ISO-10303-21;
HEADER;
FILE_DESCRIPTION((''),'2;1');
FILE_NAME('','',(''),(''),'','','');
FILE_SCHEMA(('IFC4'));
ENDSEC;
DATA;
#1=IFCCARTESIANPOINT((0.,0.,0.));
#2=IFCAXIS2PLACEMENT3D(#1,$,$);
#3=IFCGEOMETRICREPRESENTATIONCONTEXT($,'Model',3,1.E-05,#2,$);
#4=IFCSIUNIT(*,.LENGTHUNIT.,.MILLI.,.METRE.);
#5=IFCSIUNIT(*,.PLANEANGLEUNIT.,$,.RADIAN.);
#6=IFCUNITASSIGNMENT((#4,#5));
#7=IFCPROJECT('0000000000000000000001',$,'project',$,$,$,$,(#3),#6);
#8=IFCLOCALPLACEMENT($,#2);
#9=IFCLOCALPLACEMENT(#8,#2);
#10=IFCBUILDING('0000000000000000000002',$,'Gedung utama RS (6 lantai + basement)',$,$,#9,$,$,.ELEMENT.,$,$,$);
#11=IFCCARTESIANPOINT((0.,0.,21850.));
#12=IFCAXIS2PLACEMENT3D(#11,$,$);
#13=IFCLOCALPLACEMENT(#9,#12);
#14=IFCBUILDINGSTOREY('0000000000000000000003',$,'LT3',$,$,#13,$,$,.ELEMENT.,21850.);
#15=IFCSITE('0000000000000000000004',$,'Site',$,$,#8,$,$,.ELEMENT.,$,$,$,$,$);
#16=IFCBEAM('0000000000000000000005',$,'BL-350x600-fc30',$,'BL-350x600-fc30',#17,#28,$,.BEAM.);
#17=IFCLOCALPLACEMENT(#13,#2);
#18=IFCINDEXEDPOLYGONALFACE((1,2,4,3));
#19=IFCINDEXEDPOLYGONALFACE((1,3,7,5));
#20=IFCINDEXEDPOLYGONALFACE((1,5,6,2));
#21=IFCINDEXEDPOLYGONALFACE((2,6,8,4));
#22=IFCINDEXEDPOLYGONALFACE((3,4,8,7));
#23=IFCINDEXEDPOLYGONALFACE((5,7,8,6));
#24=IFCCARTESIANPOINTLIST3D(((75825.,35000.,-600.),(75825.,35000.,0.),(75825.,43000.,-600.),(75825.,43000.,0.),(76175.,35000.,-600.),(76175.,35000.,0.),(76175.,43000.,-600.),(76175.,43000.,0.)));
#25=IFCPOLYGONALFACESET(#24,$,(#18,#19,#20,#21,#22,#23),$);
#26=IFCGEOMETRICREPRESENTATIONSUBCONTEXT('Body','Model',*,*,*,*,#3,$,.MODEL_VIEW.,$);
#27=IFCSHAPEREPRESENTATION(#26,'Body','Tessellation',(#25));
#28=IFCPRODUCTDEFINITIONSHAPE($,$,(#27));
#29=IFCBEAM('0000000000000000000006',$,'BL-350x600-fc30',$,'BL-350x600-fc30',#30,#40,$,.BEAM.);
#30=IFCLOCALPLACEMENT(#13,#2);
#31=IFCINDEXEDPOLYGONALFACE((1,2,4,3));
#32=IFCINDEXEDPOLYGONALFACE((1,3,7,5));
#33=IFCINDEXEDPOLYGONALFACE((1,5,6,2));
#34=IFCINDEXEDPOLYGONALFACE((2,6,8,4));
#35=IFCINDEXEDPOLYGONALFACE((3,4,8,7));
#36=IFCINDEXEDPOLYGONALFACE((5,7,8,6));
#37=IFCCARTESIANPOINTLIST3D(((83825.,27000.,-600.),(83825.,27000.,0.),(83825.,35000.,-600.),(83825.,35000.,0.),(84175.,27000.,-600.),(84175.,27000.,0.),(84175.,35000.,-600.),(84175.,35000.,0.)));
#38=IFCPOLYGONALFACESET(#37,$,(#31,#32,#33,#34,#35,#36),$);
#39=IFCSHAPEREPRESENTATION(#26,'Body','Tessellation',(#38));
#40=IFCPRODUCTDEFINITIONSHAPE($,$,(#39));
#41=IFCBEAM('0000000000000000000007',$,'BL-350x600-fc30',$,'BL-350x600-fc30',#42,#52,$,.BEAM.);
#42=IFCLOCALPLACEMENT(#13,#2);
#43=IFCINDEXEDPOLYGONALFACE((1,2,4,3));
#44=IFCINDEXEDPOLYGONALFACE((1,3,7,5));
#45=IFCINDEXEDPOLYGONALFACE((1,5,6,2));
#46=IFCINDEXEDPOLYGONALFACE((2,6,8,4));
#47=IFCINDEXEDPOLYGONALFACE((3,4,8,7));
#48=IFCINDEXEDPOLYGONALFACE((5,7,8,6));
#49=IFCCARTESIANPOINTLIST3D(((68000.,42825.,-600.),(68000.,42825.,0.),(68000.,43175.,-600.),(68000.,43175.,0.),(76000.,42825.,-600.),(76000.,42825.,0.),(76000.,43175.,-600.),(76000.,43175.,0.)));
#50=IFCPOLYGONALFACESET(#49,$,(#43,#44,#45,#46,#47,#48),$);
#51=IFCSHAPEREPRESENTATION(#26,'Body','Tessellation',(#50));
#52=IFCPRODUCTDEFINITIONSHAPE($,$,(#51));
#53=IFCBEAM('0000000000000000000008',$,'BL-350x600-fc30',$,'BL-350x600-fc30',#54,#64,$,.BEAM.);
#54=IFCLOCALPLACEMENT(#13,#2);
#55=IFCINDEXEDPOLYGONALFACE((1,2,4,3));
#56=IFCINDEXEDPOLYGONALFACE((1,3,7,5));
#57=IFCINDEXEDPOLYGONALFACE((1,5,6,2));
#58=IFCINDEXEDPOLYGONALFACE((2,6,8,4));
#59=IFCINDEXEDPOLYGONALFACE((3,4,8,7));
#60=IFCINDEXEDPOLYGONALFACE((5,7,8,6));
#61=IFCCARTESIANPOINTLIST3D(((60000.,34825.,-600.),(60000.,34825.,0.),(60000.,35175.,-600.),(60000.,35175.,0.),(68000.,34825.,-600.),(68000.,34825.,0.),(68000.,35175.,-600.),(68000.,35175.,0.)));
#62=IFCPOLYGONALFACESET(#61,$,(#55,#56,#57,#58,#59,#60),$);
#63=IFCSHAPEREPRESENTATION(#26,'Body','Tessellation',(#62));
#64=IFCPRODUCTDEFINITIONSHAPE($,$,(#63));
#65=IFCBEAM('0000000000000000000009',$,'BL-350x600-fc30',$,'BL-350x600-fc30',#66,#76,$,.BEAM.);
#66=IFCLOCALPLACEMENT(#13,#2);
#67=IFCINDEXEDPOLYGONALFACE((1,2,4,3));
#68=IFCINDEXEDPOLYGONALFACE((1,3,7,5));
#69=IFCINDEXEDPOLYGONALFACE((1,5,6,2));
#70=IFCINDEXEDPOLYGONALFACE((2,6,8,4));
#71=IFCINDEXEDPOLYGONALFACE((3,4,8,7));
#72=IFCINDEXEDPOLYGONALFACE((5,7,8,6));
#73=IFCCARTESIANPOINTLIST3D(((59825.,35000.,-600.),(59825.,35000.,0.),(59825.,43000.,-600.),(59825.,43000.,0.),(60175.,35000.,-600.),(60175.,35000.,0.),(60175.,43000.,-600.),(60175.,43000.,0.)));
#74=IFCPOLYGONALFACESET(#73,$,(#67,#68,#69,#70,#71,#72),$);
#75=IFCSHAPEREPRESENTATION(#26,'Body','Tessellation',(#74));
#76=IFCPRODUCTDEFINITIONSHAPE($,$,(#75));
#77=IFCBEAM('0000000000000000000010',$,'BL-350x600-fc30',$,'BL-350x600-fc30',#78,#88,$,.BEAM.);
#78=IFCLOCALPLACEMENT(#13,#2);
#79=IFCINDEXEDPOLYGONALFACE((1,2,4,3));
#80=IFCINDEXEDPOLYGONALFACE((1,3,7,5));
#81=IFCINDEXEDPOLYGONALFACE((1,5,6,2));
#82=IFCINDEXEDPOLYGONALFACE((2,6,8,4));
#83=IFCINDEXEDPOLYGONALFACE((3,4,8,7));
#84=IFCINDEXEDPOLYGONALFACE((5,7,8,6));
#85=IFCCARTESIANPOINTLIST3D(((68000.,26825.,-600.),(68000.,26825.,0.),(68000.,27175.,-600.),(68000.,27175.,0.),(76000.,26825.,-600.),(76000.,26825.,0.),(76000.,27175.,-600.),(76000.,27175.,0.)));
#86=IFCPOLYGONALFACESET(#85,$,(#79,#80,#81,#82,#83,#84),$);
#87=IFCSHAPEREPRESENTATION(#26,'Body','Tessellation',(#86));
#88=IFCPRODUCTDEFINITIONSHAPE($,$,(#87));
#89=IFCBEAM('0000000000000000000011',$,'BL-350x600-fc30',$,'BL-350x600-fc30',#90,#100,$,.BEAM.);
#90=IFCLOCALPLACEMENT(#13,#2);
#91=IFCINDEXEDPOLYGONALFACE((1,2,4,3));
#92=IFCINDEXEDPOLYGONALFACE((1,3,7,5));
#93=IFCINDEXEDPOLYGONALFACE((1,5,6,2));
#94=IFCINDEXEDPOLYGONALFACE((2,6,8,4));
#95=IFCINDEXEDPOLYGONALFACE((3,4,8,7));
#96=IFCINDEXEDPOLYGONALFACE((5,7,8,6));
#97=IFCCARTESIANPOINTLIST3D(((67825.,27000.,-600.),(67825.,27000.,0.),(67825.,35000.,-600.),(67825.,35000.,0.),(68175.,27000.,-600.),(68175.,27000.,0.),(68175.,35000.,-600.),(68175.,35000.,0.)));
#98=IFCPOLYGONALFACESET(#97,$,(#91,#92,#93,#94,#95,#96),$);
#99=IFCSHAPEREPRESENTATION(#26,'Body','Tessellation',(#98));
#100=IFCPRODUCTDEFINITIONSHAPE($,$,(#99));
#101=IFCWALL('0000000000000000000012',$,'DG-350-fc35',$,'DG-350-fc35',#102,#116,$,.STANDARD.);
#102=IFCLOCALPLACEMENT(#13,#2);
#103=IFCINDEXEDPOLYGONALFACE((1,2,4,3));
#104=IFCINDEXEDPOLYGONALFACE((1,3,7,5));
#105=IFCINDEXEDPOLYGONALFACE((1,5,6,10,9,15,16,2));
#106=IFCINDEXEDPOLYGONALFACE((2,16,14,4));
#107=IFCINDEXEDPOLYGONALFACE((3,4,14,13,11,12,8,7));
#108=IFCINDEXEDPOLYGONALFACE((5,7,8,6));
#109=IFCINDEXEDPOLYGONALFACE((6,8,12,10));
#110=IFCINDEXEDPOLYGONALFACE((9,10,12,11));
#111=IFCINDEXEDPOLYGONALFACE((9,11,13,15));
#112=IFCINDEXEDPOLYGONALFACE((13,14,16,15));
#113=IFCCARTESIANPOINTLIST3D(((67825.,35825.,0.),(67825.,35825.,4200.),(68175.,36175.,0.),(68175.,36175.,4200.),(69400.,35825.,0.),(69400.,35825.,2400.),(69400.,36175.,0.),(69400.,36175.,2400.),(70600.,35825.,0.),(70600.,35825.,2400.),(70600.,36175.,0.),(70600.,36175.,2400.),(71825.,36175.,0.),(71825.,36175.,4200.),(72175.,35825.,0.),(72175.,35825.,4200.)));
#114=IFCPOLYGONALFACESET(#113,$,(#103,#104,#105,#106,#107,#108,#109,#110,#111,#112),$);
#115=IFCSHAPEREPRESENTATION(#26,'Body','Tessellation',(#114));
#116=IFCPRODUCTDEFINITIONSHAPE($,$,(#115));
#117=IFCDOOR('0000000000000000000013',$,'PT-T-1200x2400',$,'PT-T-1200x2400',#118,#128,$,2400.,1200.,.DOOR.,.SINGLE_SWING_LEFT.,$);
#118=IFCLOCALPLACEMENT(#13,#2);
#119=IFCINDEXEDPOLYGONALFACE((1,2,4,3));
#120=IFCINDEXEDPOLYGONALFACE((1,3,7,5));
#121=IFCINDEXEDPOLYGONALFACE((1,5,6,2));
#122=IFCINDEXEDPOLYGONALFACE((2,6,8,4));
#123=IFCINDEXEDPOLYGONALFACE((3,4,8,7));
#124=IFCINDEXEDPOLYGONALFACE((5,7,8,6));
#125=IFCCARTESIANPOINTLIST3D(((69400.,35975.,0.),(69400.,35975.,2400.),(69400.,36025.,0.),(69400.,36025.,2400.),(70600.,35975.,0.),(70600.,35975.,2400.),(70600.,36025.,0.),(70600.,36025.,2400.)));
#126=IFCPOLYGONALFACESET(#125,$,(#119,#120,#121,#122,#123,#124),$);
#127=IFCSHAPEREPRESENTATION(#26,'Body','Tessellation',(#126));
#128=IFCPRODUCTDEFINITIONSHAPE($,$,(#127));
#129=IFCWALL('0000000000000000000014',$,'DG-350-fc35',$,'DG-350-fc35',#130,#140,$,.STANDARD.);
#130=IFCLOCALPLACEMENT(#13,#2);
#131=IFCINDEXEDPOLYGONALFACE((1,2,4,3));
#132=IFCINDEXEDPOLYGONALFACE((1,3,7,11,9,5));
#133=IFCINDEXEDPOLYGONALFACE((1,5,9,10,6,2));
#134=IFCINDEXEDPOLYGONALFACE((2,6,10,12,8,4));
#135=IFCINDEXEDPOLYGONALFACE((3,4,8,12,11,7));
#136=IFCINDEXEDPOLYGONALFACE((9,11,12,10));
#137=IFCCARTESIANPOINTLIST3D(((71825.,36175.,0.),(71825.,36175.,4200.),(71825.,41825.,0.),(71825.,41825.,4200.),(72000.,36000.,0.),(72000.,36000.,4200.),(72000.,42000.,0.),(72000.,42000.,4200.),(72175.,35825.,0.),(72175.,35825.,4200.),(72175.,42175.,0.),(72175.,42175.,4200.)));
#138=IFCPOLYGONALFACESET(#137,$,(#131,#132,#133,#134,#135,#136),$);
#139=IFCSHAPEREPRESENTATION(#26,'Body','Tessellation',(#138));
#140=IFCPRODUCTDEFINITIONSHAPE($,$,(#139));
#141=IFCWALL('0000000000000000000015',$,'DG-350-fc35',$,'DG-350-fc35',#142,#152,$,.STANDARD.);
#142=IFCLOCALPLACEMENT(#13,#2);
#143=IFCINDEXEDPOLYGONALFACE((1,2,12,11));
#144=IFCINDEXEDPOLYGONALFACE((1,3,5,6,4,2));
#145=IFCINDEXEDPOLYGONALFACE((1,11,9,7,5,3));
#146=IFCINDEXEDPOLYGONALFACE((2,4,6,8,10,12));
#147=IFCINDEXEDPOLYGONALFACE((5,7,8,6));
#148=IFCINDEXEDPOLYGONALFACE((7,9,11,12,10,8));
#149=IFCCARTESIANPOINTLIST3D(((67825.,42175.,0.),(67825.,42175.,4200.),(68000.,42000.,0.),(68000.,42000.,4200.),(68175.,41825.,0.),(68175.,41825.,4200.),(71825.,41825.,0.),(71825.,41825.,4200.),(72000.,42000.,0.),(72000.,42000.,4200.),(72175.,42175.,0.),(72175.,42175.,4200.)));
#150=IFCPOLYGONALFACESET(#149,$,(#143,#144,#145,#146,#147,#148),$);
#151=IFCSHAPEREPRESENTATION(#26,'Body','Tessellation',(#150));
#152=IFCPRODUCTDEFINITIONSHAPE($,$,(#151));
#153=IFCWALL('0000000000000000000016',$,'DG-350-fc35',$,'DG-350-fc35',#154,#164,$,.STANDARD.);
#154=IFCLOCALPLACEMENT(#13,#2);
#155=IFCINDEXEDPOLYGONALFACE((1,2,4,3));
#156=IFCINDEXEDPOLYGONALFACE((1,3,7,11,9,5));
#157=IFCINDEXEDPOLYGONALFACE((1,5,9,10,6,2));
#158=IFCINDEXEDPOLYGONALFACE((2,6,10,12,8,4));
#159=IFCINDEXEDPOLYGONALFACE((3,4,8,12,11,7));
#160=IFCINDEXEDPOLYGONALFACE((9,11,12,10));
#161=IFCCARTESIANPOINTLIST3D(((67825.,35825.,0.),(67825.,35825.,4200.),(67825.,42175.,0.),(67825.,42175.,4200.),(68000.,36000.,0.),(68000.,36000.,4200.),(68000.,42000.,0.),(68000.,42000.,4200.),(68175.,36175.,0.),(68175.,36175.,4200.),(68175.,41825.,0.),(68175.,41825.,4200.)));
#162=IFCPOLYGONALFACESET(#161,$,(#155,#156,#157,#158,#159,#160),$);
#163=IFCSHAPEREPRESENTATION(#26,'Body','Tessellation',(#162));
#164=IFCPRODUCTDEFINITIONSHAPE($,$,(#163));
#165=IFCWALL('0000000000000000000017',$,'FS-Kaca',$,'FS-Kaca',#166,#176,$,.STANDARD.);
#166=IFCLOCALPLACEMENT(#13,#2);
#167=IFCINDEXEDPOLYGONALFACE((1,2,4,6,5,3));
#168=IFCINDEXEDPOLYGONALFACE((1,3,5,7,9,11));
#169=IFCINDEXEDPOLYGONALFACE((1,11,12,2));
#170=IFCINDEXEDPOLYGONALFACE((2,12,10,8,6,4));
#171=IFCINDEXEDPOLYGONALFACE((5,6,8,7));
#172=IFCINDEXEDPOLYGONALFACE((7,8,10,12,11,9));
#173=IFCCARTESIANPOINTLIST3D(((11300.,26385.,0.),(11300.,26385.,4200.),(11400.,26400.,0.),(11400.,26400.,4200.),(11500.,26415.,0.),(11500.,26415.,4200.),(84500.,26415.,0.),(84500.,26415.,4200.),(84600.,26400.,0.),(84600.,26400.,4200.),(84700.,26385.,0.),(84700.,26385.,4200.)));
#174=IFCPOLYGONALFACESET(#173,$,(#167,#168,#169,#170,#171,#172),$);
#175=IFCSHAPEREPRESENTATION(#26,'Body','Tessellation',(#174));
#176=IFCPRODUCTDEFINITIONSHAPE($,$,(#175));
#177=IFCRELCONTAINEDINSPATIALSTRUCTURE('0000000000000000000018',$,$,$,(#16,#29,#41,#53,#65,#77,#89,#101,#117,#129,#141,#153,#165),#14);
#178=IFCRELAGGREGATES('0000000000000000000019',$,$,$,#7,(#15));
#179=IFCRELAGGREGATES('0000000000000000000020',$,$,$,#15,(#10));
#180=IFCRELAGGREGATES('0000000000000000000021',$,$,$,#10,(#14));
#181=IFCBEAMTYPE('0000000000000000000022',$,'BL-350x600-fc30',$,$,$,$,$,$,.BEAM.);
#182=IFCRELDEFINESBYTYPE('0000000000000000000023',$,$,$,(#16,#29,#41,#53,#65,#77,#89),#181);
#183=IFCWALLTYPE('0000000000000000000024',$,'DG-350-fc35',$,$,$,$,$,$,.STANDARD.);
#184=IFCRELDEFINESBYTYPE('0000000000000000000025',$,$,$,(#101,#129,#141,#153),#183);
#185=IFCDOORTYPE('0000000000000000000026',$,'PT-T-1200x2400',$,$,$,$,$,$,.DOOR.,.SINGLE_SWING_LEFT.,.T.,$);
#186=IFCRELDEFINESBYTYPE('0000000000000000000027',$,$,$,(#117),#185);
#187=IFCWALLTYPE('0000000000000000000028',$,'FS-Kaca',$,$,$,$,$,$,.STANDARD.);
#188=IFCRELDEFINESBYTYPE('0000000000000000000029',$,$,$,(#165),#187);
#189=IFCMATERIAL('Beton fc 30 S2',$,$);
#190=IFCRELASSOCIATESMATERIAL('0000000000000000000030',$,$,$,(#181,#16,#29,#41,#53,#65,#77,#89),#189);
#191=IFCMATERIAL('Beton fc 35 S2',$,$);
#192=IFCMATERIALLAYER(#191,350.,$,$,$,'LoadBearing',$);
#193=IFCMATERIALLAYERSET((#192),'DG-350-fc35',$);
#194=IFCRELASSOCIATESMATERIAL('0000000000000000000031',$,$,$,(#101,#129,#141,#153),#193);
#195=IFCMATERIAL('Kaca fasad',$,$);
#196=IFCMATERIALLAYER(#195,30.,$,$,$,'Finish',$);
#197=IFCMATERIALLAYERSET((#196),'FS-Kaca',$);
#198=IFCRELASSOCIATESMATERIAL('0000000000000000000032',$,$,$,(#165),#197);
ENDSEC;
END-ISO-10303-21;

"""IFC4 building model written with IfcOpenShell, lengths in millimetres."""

from ifc_helpers import new_model, si_unit, frame, frame_2d, origin, origin_2d, place, context, subcontext, project, spatial, polyline, rectangle, outline, extrude, material, layer, layer_set, layer_usage, material_profile, profile_set, profile_usage, type_object, element, fill, save


model = new_model("IFC4")

# Units and contexts
model_context = context("Model", 3, precision=1e-05, world=origin())
body_context = subcontext(model_context, "Body", "Model", "MODEL_VIEW")
ifc_project = project(units=[si_unit("LENGTHUNIT", "METRE", prefix="MILLI"), si_unit("PLANEANGLEUNIT", "RADIAN")], contexts=[model_context])

# Site, building, storey
site_placement = place(None, origin())
site = spatial("IfcSite", under=ifc_project, at=site_placement, Name="Site", CompositionType="ELEMENT")
building_placement = place(site_placement, origin())
building = spatial("IfcBuilding", under=site, at=building_placement, Name="Gedung utama RS (6 lantai + basement)", CompositionType="ELEMENT")
storey_placement = place(building_placement, frame((0.0, 0.0, 21850.0)))
storey = spatial("IfcBuildingStorey", under=building, at=storey_placement, Name="LT3", CompositionType="ELEMENT", Elevation=21850.0)

# Beams
ifc_material_1 = material(Name="Beton fc 30 S2")
ifc_material_profile_1 = material_profile(ifc_material_1, rectangle(XDim=350.0, YDim=600.0, at=origin_2d()), Name="BL-350x600-fc30")
ifc_profile_set_1 = profile_set([ifc_material_profile_1], Name="BL-350x600-fc30")
ifc_profile_usage_1 = profile_usage(ifc_profile_set_1, cardinal=8)
beam_type = type_object("IfcBeamType", Name="BL-350x600-fc30", PredefinedType="BEAM", material=ifc_profile_set_1)
for number, where, name in (
    (1, (76000.0, 35000.0, -300.0), "BL-350x600-fc30"),
    (2, (84000.0, 27000.0, -300.0), "BL-350x600-fc30"),
):
    element("IfcBeam", number, at=place(storey_placement, frame(where)), inside=storey, type_object=beam_type, material=ifc_profile_usage_1, Name=name, ObjectType="BL-350x600-fc30", PredefinedType="BEAM", context=body_context, shape_type="SweptSolid", body=[
        extrude(rectangle(XDim=350.0, YDim=600.0, at=origin_2d()), frame((0.0, 0.0, 0.0), z_axis=(0.0, 1.0, 0.0), x_axis=(-1.0, 0.0, 0.0)), (0.0, 0.0, 1.0), 8000.0),
    ])
for number, where, name in (
    (3, (68000.0, 43000.0, -300.0), "BL-350x600-fc30"),
    (4, (60000.0, 35000.0, -300.0), "BL-350x600-fc30"),
):
    element("IfcBeam", number, at=place(storey_placement, frame(where)), inside=storey, type_object=beam_type, material=ifc_profile_usage_1, Name=name, ObjectType="BL-350x600-fc30", PredefinedType="BEAM", context=body_context, shape_type="SweptSolid", body=[
        extrude(rectangle(XDim=350.0, YDim=600.0, at=origin_2d()), frame((0.0, 0.0, 0.0), z_axis=(1.0, 0.0, 0.0), x_axis=(0.0, 1.0, 0.0)), (0.0, 0.0, 1.0), 8000.0),
    ])
beam_1_placement = place(storey_placement, frame((60000.0, 35000.0, -300.0)))
element("IfcBeam", 5, at=beam_1_placement, inside=storey, type_object=beam_type, material=ifc_profile_usage_1, Name="BL-350x600-fc30", ObjectType="BL-350x600-fc30", PredefinedType="BEAM", context=body_context, shape_type="SweptSolid", body=[
    extrude(rectangle(XDim=350.0, YDim=600.0, at=origin_2d()), frame((0.0, 0.0, 0.0), z_axis=(0.0, 1.0, 0.0), x_axis=(-1.0, 0.0, 0.0)), (0.0, 0.0, 1.0), 8000.0),
])
beam_2_placement = place(storey_placement, frame((68000.0, 27000.0, -300.0)))
element("IfcBeam", 6, at=beam_2_placement, inside=storey, type_object=beam_type, material=ifc_profile_usage_1, Name="BL-350x600-fc30", ObjectType="BL-350x600-fc30", PredefinedType="BEAM", context=body_context, shape_type="SweptSolid", body=[
    extrude(rectangle(XDim=350.0, YDim=600.0, at=origin_2d()), frame((0.0, 0.0, 0.0), z_axis=(1.0, 0.0, 0.0), x_axis=(0.0, 1.0, 0.0)), (0.0, 0.0, 1.0), 8000.0),
])
beam_3_placement = place(storey_placement, frame((68000.0, 27000.0, -300.0)))
element("IfcBeam", 7, at=beam_3_placement, inside=storey, type_object=beam_type, material=ifc_profile_usage_1, Name="BL-350x600-fc30", ObjectType="BL-350x600-fc30", PredefinedType="BEAM", context=body_context, shape_type="SweptSolid", body=[
    extrude(rectangle(XDim=350.0, YDim=600.0, at=origin_2d()), frame((0.0, 0.0, 0.0), z_axis=(0.0, 1.0, 0.0), x_axis=(-1.0, 0.0, 0.0)), (0.0, 0.0, 1.0), 8000.0),
])

# Wall, opening, door
ifc_material_2 = material(Name="Beton fc 35 S2")
ifc_layer_1 = layer(ifc_material_2, 350.0, Category="LoadBearing")
ifc_layer_set_1 = layer_set([ifc_layer_1], Name="DG-350-fc35")
ifc_layer_usage_1 = layer_usage(ifc_layer_set_1, "AXIS2", "NEGATIVE", 175.0)
wall_type_1 = type_object("IfcWallType", Name="DG-350-fc35", PredefinedType="STANDARD")
wall_1_placement = place(storey_placement, frame((68000.0, 36000.0, 0.0), z_axis=(0.0, 0.0, 1.0), x_axis=(1.0, 0.0, 0.0)))
wall_1 = element("IfcWall", 8, at=wall_1_placement, inside=storey, type_object=wall_type_1, material=ifc_layer_usage_1, Name="DG-350-fc35", ObjectType="DG-350-fc35", PredefinedType="STANDARD", context=body_context, shape_type="SweptSolid", body=[
    extrude(outline(polyline([(-175.0, -175.0), (0.0, 0.0), (175.0, 175.0), (3825.0, 175.0), (4000.0, 0.0), (4175.0, -175.0), (-175.0, -175.0)])), origin(), (0.0, 0.0, 1.0), 4200.0),
])
opening_placement = place(wall_1_placement, frame((1400.0, 0.0, 0.0), z_axis=(0.0, 0.0, 1.0), x_axis=(1.0, 0.0, 0.0)))
opening = element("IfcOpeningElement", 9, at=opening_placement, cuts=wall_1, PredefinedType="OPENING", context=body_context, shape_type="SweptSolid", body=[
    extrude(rectangle(XDim=1200.0, YDim=370.0, at=frame_2d((600.0, 0.0))), origin(), (0.0, 0.0, 1.0), 2400.0),
])
door_type = type_object("IfcDoorType", Name="PT-T-1200x2400", OperationType="SINGLE_SWING_LEFT", ParameterTakesPrecedence=True, PredefinedType="DOOR")
door_placement = place(opening_placement, origin())
door = element("IfcDoor", 10, at=door_placement, inside=storey, type_object=door_type, Name="PT-T-1200x2400", ObjectType="PT-T-1200x2400", OperationType="SINGLE_SWING_LEFT", OverallHeight=2400.0, OverallWidth=1200.0, PredefinedType="DOOR", context=body_context, shape_type="SweptSolid", body=[
    extrude(rectangle(XDim=1200.0, YDim=50.0, at=frame_2d((600.0, 0.0))), origin(), (0.0, 0.0, 1.0), 2400.0),
])
fill(opening, door)

# Walls
wall_2_placement = place(storey_placement, frame((72000.0, 36000.0, 0.0), z_axis=(0.0, 0.0, 1.0), x_axis=(0.0, 1.0, 0.0)))
element("IfcWall", 11, at=wall_2_placement, inside=storey, type_object=wall_type_1, material=ifc_layer_usage_1, Name="DG-350-fc35", ObjectType="DG-350-fc35", PredefinedType="STANDARD", context=body_context, shape_type="SweptSolid", body=[
    extrude(outline(polyline([(-175.0, -175.0), (0.0, 0.0), (175.0, 175.0), (5825.0, 175.0), (6000.0, 0.0), (6175.0, -175.0), (-175.0, -175.0)])), origin(), (0.0, 0.0, 1.0), 4200.0),
])
wall_3_placement = place(storey_placement, frame((72000.0, 42000.0, 0.0), z_axis=(0.0, 0.0, 1.0), x_axis=(-1.0, 0.0, 0.0)))
element("IfcWall", 12, at=wall_3_placement, inside=storey, type_object=wall_type_1, material=ifc_layer_usage_1, Name="DG-350-fc35", ObjectType="DG-350-fc35", PredefinedType="STANDARD", context=body_context, shape_type="SweptSolid", body=[
    extrude(outline(polyline([(-175.0, -175.0), (0.0, 0.0), (175.0, 175.0), (3825.0, 175.0), (4000.0, 0.0), (4175.0, -175.0), (-175.0, -175.0)])), origin(), (0.0, 0.0, 1.0), 4200.0),
])
wall_4_placement = place(storey_placement, frame((68000.0, 42000.0, 0.0), z_axis=(0.0, 0.0, 1.0), x_axis=(0.0, -1.0, 0.0)))
element("IfcWall", 13, at=wall_4_placement, inside=storey, type_object=wall_type_1, material=ifc_layer_usage_1, Name="DG-350-fc35", ObjectType="DG-350-fc35", PredefinedType="STANDARD", context=body_context, shape_type="SweptSolid", body=[
    extrude(outline(polyline([(-175.0, -175.0), (0.0, 0.0), (175.0, 175.0), (5825.0, 175.0), (6000.0, 0.0), (6175.0, -175.0), (-175.0, -175.0)])), origin(), (0.0, 0.0, 1.0), 4200.0),
])
ifc_material_3 = material(Name="Kaca fasad")
ifc_layer_2 = layer(ifc_material_3, 30.0, Category="Finish")
ifc_layer_set_2 = layer_set([ifc_layer_2], Name="FS-Kaca")
ifc_layer_usage_2 = layer_usage(ifc_layer_set_2, "AXIS2", "NEGATIVE", 15.0)
wall_type_2 = type_object("IfcWallType", Name="FS-Kaca", PredefinedType="STANDARD")
wall_5_placement = place(storey_placement, frame((84600.0, 26400.0, 0.0), z_axis=(0.0, 0.0, 1.0), x_axis=(-1.0, 0.0, 0.0)))
element("IfcWall", 14, at=wall_5_placement, inside=storey, type_object=wall_type_2, material=ifc_layer_usage_2, Name="FS-Kaca", ObjectType="FS-Kaca", PredefinedType="STANDARD", context=body_context, shape_type="SweptSolid", body=[
    extrude(outline(polyline([(100.0, -15.0), (0.0, 0.0), (-100.0, 15.0), (73300.0, 15.0), (73200.0, 0.0), (73100.0, -15.0), (100.0, -15.0)])), origin(), (0.0, 0.0, 1.0), 4200.0),
])

save(model, "model.ifc")
